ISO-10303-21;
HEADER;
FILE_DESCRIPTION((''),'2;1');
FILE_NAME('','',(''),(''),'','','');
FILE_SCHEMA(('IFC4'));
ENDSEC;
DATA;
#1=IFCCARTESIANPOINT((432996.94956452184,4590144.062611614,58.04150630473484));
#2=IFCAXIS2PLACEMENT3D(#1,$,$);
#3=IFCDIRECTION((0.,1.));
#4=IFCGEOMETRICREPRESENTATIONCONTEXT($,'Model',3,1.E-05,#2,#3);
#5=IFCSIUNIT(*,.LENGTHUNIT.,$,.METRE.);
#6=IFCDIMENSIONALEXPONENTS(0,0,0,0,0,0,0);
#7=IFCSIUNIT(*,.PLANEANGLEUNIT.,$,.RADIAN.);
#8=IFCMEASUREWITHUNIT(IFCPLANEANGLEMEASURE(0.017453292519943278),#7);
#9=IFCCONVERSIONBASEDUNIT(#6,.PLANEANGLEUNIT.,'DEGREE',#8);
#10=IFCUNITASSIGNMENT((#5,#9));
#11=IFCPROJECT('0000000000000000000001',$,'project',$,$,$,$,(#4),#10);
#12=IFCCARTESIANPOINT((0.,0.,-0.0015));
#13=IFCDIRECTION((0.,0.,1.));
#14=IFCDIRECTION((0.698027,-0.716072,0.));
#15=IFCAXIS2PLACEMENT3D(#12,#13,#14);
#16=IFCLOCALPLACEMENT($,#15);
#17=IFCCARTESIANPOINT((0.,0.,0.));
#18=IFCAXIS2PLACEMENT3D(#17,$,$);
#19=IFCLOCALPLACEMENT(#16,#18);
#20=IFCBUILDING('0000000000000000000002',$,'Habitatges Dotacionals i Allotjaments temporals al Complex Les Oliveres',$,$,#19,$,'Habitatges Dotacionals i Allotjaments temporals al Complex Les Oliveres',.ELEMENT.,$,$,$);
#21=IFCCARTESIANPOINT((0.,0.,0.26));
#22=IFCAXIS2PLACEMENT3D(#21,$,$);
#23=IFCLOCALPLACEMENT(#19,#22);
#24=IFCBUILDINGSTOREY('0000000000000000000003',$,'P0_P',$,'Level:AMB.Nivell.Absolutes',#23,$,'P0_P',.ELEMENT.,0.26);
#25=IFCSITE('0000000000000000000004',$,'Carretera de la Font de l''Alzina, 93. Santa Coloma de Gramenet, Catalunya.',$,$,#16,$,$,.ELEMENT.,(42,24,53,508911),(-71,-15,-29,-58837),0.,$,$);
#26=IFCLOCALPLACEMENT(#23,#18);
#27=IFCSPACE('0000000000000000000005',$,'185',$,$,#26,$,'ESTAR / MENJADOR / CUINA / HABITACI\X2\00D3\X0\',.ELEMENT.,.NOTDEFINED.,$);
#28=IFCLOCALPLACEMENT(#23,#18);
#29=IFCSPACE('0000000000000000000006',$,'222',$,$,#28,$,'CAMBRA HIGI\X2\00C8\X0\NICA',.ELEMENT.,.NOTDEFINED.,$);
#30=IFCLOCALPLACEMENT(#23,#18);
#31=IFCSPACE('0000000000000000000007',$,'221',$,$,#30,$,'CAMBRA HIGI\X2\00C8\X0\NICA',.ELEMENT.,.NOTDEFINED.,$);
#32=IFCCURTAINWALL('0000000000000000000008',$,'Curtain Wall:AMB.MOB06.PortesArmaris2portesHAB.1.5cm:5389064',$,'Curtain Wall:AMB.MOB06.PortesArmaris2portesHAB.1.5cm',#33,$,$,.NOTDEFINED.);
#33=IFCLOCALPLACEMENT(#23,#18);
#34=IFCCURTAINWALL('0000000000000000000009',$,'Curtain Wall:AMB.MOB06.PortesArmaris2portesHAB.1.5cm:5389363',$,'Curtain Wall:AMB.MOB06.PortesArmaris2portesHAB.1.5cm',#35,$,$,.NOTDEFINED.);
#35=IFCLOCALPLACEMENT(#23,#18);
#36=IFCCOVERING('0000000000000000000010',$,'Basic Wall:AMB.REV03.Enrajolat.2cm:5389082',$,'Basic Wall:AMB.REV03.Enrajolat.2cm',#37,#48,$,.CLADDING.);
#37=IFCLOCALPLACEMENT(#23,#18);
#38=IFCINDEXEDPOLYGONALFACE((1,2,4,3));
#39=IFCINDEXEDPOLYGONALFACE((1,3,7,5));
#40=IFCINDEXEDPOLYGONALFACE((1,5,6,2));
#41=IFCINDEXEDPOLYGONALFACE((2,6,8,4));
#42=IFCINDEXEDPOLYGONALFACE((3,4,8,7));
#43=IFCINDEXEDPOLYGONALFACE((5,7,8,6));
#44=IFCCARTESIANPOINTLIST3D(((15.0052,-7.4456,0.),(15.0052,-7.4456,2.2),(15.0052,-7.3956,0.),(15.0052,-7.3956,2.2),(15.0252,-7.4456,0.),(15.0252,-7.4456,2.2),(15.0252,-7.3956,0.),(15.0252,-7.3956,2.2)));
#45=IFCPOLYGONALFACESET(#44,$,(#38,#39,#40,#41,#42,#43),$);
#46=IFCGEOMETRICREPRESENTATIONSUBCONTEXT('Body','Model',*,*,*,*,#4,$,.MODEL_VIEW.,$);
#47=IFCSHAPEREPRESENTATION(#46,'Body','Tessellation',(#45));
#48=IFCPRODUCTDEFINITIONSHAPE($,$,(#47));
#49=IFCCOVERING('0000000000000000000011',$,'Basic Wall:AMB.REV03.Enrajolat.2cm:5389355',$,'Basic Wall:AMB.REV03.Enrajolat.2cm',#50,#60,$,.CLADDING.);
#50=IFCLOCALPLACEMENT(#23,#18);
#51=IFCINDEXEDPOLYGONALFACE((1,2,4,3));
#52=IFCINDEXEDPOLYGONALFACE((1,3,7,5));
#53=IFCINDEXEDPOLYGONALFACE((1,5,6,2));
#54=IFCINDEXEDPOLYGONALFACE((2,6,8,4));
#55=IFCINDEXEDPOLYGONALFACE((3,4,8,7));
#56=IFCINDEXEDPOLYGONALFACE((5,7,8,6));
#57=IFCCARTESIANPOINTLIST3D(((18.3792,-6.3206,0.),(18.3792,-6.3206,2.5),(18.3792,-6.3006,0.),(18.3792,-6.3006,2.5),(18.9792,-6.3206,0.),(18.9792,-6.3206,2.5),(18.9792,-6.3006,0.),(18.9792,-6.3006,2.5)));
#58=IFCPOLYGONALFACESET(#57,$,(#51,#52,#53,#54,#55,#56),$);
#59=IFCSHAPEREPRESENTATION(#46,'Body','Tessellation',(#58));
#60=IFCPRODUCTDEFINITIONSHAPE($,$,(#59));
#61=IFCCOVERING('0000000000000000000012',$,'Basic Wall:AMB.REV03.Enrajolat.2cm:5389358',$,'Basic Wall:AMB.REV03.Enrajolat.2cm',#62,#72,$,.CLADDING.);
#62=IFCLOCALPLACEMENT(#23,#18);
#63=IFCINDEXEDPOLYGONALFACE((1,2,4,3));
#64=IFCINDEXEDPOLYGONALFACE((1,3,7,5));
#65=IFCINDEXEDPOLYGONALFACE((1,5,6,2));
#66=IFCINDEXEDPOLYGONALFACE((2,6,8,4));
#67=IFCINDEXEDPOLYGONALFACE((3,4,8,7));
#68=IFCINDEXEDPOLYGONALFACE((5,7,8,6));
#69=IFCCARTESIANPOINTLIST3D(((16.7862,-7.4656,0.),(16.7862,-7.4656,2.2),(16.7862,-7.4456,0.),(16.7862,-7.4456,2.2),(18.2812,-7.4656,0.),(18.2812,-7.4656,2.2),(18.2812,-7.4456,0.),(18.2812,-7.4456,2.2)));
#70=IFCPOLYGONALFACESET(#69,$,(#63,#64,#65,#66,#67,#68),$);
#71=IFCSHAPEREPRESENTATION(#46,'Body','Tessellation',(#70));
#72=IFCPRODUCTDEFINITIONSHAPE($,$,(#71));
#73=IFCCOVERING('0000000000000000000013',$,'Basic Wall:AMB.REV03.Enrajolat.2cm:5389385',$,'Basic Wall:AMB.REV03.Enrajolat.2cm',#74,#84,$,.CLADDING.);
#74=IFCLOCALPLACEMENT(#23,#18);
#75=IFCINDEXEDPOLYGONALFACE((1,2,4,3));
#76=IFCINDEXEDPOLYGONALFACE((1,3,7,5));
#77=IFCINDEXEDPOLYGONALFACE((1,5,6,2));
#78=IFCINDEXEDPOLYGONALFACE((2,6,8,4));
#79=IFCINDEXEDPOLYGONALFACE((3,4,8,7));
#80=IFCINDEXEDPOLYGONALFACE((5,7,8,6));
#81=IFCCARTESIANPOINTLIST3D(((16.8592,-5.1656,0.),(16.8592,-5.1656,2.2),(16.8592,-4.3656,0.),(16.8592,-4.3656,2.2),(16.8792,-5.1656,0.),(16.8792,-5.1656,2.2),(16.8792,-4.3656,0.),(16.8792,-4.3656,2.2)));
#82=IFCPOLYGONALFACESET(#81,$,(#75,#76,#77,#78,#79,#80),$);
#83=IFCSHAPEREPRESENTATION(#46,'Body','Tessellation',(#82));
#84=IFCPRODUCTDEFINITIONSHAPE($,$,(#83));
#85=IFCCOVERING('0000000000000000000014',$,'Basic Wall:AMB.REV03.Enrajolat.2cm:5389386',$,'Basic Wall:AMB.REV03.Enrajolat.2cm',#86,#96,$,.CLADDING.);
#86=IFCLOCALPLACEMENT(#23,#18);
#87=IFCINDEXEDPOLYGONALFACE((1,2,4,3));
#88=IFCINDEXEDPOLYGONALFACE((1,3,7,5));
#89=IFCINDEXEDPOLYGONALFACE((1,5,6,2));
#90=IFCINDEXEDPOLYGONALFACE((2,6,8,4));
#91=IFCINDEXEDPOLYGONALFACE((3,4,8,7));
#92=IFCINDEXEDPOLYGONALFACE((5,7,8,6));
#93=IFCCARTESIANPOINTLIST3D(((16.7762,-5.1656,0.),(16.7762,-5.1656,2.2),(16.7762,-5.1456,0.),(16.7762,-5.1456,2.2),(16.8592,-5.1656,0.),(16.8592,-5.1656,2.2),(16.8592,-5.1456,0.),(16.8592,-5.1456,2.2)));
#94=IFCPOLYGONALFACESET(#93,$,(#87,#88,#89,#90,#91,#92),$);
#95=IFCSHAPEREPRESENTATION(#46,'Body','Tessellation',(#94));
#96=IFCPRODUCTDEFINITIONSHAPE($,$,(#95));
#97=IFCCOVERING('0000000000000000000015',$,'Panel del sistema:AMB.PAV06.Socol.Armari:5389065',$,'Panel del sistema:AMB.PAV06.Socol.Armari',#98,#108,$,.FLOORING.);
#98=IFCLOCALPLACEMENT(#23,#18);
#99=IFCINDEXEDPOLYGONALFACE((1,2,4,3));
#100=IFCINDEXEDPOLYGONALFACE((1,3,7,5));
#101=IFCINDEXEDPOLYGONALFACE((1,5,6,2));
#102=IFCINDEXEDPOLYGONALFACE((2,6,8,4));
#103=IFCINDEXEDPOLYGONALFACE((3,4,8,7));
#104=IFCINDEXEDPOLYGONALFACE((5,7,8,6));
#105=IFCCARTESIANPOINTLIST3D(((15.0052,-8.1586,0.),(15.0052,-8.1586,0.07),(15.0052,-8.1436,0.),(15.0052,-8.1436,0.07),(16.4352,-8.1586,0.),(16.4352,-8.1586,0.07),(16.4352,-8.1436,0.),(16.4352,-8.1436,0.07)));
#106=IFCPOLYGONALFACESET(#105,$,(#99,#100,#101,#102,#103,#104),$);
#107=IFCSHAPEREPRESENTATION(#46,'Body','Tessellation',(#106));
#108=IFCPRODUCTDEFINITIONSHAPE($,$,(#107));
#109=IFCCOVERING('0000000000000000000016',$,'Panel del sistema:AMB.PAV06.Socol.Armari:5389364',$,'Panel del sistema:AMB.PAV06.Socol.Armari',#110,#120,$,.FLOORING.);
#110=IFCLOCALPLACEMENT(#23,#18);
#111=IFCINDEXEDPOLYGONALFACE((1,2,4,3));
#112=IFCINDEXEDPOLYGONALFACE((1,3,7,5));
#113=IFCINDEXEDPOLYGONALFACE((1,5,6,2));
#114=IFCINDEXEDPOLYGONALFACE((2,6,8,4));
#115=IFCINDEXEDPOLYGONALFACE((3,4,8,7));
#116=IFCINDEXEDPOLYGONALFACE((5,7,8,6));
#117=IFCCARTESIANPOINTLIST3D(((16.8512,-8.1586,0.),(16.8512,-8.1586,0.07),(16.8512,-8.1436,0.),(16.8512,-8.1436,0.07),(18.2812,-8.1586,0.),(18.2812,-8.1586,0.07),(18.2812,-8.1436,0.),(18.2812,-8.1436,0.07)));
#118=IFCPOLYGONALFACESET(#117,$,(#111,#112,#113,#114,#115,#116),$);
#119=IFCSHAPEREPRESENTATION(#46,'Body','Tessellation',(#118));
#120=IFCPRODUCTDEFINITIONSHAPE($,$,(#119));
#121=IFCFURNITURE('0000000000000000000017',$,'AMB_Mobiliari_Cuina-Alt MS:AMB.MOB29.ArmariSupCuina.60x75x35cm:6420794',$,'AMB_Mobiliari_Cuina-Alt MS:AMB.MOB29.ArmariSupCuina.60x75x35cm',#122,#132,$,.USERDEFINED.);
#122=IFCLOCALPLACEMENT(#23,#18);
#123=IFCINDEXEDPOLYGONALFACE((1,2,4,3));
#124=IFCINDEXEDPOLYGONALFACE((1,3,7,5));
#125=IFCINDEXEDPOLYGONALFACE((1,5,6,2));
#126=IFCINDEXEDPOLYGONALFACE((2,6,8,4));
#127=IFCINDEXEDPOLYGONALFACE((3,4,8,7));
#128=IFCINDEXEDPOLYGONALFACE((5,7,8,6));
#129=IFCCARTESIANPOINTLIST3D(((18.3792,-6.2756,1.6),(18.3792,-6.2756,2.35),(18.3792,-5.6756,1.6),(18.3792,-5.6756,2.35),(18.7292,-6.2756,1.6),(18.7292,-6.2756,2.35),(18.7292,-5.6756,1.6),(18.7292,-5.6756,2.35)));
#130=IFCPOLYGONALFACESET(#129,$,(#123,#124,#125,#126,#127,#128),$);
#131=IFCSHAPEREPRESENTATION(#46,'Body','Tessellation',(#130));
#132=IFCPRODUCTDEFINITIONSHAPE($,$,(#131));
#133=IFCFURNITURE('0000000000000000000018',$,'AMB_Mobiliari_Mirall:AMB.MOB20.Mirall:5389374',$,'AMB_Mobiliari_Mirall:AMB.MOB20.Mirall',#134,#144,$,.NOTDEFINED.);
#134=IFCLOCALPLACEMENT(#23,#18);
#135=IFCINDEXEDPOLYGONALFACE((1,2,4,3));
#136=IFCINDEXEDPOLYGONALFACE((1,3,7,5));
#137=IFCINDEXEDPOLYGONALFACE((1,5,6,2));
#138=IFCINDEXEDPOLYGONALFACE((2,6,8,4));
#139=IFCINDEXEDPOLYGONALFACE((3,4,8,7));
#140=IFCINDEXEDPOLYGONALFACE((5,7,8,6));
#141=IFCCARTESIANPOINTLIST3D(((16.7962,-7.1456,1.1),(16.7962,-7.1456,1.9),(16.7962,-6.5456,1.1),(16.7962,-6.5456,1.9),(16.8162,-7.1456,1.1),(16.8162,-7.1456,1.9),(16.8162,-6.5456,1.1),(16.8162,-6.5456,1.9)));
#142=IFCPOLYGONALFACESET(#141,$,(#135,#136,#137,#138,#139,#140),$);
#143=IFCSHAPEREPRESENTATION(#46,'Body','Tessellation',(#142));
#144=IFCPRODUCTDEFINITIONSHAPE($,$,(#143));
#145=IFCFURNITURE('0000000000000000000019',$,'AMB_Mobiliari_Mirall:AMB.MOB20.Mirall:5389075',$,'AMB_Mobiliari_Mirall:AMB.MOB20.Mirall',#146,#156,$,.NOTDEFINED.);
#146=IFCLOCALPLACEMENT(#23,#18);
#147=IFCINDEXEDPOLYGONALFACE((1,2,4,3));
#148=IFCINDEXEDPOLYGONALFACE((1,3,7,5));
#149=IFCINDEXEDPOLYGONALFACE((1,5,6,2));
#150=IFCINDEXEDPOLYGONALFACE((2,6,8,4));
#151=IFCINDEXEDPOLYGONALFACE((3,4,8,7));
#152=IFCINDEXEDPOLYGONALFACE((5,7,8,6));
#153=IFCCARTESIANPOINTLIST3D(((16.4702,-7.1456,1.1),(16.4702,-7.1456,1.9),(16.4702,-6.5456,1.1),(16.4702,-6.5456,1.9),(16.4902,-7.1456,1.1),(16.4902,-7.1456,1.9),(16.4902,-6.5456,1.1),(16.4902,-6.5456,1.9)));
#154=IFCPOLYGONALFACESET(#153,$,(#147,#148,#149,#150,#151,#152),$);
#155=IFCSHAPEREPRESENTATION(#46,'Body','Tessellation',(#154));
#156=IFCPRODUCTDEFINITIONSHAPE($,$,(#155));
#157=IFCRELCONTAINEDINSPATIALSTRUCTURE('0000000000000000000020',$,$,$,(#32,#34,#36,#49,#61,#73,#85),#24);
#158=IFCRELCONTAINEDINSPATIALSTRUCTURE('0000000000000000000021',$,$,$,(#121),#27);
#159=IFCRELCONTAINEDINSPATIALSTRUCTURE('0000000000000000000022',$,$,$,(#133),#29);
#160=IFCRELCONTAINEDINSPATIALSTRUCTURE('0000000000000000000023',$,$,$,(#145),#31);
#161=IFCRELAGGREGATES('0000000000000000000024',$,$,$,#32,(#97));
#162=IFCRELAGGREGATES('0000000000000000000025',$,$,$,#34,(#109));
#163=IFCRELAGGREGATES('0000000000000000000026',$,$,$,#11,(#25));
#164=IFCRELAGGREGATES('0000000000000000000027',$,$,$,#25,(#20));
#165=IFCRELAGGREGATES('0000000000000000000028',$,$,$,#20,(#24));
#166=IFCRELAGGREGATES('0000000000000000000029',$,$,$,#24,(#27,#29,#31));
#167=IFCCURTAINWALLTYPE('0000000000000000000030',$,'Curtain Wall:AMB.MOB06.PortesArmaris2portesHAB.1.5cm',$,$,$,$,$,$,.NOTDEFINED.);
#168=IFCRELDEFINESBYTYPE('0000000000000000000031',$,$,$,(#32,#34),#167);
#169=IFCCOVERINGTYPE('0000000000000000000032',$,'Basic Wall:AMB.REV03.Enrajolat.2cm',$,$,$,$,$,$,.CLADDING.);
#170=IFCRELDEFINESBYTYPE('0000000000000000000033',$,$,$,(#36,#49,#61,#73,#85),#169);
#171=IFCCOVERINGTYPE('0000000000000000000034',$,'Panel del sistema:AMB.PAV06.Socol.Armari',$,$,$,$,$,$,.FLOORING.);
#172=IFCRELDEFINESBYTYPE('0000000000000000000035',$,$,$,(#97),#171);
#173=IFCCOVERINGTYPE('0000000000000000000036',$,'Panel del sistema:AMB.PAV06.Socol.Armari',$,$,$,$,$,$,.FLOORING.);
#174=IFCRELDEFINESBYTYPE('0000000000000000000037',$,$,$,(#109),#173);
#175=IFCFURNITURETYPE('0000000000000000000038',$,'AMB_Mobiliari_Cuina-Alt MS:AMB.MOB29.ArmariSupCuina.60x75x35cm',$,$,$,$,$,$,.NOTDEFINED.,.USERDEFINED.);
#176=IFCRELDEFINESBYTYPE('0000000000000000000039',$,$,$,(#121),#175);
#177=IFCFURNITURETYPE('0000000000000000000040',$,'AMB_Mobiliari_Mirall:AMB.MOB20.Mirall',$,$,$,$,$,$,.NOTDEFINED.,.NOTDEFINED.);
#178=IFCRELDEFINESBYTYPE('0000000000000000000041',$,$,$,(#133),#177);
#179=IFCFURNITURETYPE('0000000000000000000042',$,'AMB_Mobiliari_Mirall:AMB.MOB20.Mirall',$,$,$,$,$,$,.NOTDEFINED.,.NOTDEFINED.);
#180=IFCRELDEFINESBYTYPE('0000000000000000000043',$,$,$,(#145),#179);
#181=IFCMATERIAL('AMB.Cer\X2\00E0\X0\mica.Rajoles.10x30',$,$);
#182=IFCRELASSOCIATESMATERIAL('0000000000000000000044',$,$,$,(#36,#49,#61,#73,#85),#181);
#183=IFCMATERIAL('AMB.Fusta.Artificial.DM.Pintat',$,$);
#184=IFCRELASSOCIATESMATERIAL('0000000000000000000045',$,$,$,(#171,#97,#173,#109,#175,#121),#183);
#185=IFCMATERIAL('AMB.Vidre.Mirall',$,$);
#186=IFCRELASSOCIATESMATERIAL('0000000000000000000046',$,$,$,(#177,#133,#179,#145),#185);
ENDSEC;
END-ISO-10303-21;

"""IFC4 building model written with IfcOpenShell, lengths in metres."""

from ifc_helpers import new_model, entity, si_unit, converted_unit, direction, frame, origin, place, context, subcontext, project, spatial, indexed_curve, outline, extrude, source, transform, mapped, material, type_object, type_shapes, element, aggregate, save


model = new_model("IFC4")

# Units and contexts
model_context = context("Model", 3, precision=1e-05, world=frame((432996.94956452184, 4590144.062611614, 58.04150630473484)), true_north=direction((0.0, 1.0)))
body_context = subcontext(model_context, "Body", "Model", "MODEL_VIEW")
ifc_project = project(units=[si_unit("LENGTHUNIT", "METRE"), converted_unit("PLANEANGLEUNIT", "DEGREE", entity("IfcPlaneAngleMeasure", 0.017453292519943278), si_unit("PLANEANGLEUNIT", "RADIAN"), dimensions=[0, 0, 0, 0, 0, 0, 0])], contexts=[model_context])

# Site, building, storey
site_placement = place(None, frame((0.0, 0.0, -0.0015), z_axis=(0.0, 0.0, 1.0), x_axis=(0.698027, -0.716072, 0.0)))
site = spatial("IfcSite", under=ifc_project, at=site_placement, Name="Carretera de la Font de l'Alzina, 93. Santa Coloma de Gramenet, Catalunya.", CompositionType="ELEMENT", RefLatitude=(42, 24, 53, 508911), RefLongitude=(-71, -15, -29, -58837), RefElevation=0.0)
building_placement = place(site_placement, origin())
building = spatial("IfcBuilding", under=site, at=building_placement, Name="Habitatges Dotacionals i Allotjaments temporals al Complex Les Oliveres", LongName="Habitatges Dotacionals i Allotjaments temporals al Complex Les Oliveres", CompositionType="ELEMENT")
storey_placement = place(building_placement, frame((0.0, 0.0, 0.26)))
storey = spatial("IfcBuildingStorey", under=building, at=storey_placement, Name="P0_P", ObjectType="Level:AMB.Nivell.Absolutes", LongName="P0_P", CompositionType="ELEMENT", Elevation=0.26)

# Curtain walls
curtain_wall_type = type_object("IfcCurtainWallType", Name="Curtain Wall:AMB.MOB06.PortesArmaris2portesHAB.1.5cm", PredefinedType="NOTDEFINED")
curtain_wall_1_placement = place(storey_placement, frame((0.0, 0.0, -0.26)))
curtain_wall_1 = element("IfcCurtainWall", 1, at=curtain_wall_1_placement, inside=storey, type_object=curtain_wall_type, Name="Curtain Wall:AMB.MOB06.PortesArmaris2portesHAB.1.5cm:5389064", ObjectType="Curtain Wall:AMB.MOB06.PortesArmaris2portesHAB.1.5cm", PredefinedType="NOTDEFINED")
ifc_material_1 = material(Name="AMB.Fusta.Artificial.DM.Pintat")
curtain_wall_2_placement = place(storey_placement, frame((0.0, 0.0, -0.26)))
curtain_wall_2 = element("IfcCurtainWall", 2, at=curtain_wall_2_placement, inside=storey, type_object=curtain_wall_type, Name="Curtain Wall:AMB.MOB06.PortesArmaris2portesHAB.1.5cm:5389363", ObjectType="Curtain Wall:AMB.MOB06.PortesArmaris2portesHAB.1.5cm", PredefinedType="NOTDEFINED")

# Coverings
ifc_material_2 = material(Name="AMB.Ceràmica.Rajoles.10x30")
covering_type_1 = type_object("IfcCoveringType", Name="Basic Wall:AMB.REV03.Enrajolat.2cm", PredefinedType="CLADDING")
covering_1_placement = place(storey_placement, frame((15.0152, -7.4456, 0.0), z_axis=(0.0, 0.0, 1.0), x_axis=(0.0, 1.0, 0.0)))
element("IfcCovering", 3, at=covering_1_placement, inside=storey, type_object=covering_type_1, material=ifc_material_2, Name="Basic Wall:AMB.REV03.Enrajolat.2cm:5389082", ObjectType="Basic Wall:AMB.REV03.Enrajolat.2cm", PredefinedType="CLADDING", context=body_context, shape_type="SweptSolid", body=[
    extrude(outline(indexed_curve([(0.05, 0.01), (0.0, 0.01), (0.0, -0.01), (0.05, -0.01), (0.05, 0.01)], self_intersect=False)), origin(), (0.0, 0.0, 1.0), 2.2),
])
covering_2_placement = place(storey_placement, frame((18.3792, -6.3106, 0.0)))
element("IfcCovering", 4, at=covering_2_placement, inside=storey, type_object=covering_type_1, material=ifc_material_2, Name="Basic Wall:AMB.REV03.Enrajolat.2cm:5389355", ObjectType="Basic Wall:AMB.REV03.Enrajolat.2cm", PredefinedType="CLADDING", context=body_context, shape_type="SweptSolid", body=[
    extrude(outline(indexed_curve([(0.6, 0.01), (0.0, 0.01), (0.0, -0.01), (0.6, -0.01), (0.6, 0.01)], self_intersect=False)), origin(), (0.0, 0.0, 1.0), 2.5),
])
covering_3_placement = place(storey_placement, frame((18.2812, -7.4556, 0.0), z_axis=(0.0, 0.0, 1.0), x_axis=(-1.0, 0.0, 0.0)))
element("IfcCovering", 5, at=covering_3_placement, inside=storey, type_object=covering_type_1, material=ifc_material_2, Name="Basic Wall:AMB.REV03.Enrajolat.2cm:5389358", ObjectType="Basic Wall:AMB.REV03.Enrajolat.2cm", PredefinedType="CLADDING", context=body_context, shape_type="SweptSolid", body=[
    extrude(outline(indexed_curve([(1.495, 0.01), (0.0, 0.01), (0.0, -0.01), (1.495, -0.01), (1.495, 0.01)], self_intersect=False)), origin(), (0.0, 0.0, 1.0), 2.2),
])
covering_4_placement = place(storey_placement, frame((16.8692, -5.1656, 0.0), z_axis=(0.0, 0.0, 1.0), x_axis=(0.0, 1.0, 0.0)))
element("IfcCovering", 6, at=covering_4_placement, inside=storey, type_object=covering_type_1, material=ifc_material_2, Name="Basic Wall:AMB.REV03.Enrajolat.2cm:5389385", ObjectType="Basic Wall:AMB.REV03.Enrajolat.2cm", PredefinedType="CLADDING", context=body_context, shape_type="SweptSolid", body=[
    extrude(outline(indexed_curve([(0.8, 0.01), (0.0, 0.01), (0.0, -0.01), (0.8, -0.01), (0.8, 0.01)], self_intersect=False)), origin(), (0.0, 0.0, 1.0), 2.2),
])
covering_5_placement = place(storey_placement, frame((16.8592, -5.1556, 0.0), z_axis=(0.0, 0.0, 1.0), x_axis=(-1.0, 0.0, 0.0)))
element("IfcCovering", 7, at=covering_5_placement, inside=storey, type_object=covering_type_1, material=ifc_material_2, Name="Basic Wall:AMB.REV03.Enrajolat.2cm:5389386", ObjectType="Basic Wall:AMB.REV03.Enrajolat.2cm", PredefinedType="CLADDING", context=body_context, shape_type="SweptSolid", body=[
    extrude(outline(indexed_curve([(0.083, 0.01), (0.0, 0.01), (0.0, -0.01), (0.083, -0.01), (0.083, 0.01)], self_intersect=False)), origin(), (0.0, 0.0, 1.0), 2.2),
])

# Coverings
covering_type_2 = type_object("IfcCoveringType", Name="Panel del sistema:AMB.PAV06.Socol.Armari", PredefinedType="FLOORING", material=ifc_material_1)
shared_shape_1 = source(origin(), body_context, "Body", "SweptSolid", [
    extrude(outline(indexed_curve([(-0.0075, -0.715), (0.0075, -0.715), (0.0075, 0.715), (-0.0075, 0.715), (-0.0075, -0.715)], self_intersect=False)), frame((0.0, -0.0075, 0.0), z_axis=(0.0, 0.0, 1.0), x_axis=(0.0, 1.0, 0.0)), (0.0, 0.0, 1.0), 0.07),
])
type_shapes(covering_type_2, [shared_shape_1])
covering_6_placement = place(storey_placement, frame((15.7202, -8.1586, 0.0), z_axis=(0.0, 0.0, 1.0), x_axis=(-1.0, 0.0, 0.0)))
covering_6 = element("IfcCovering", 8, at=covering_6_placement, type_object=covering_type_2, material=ifc_material_1, Name="Panel del sistema:AMB.PAV06.Socol.Armari:5389065", ObjectType="Panel del sistema:AMB.PAV06.Socol.Armari", PredefinedType="FLOORING", context=body_context, shape_type="MappedRepresentation", body=[
    mapped(shared_shape_1, transform((0.0, 0.0, 0.0), scale=1.0)),
])
aggregate(curtain_wall_1, [covering_6])
covering_type_3 = type_object("IfcCoveringType", Name="Panel del sistema:AMB.PAV06.Socol.Armari", PredefinedType="FLOORING", material=ifc_material_1)
shared_shape_2 = source(origin(), body_context, "Body", "SweptSolid", [
    extrude(outline(indexed_curve([(-0.0075, -0.715), (0.0075, -0.715), (0.0075, 0.715), (-0.0075, 0.715), (-0.0075, -0.715)], self_intersect=False)), frame((0.0, 0.0075, 0.0), z_axis=(0.0, 0.0, 1.0), x_axis=(0.0, 1.0, 0.0)), (0.0, 0.0, 1.0), 0.07),
])
type_shapes(covering_type_3, [shared_shape_2])
covering_7_placement = place(storey_placement, frame((17.5662, -8.1586, 0.0)))
covering_7 = element("IfcCovering", 9, at=covering_7_placement, type_object=covering_type_3, material=ifc_material_1, Name="Panel del sistema:AMB.PAV06.Socol.Armari:5389364", ObjectType="Panel del sistema:AMB.PAV06.Socol.Armari", PredefinedType="FLOORING", context=body_context, shape_type="MappedRepresentation", body=[
    mapped(shared_shape_2, transform((0.0, 0.0, 0.0), scale=1.0)),
])
aggregate(curtain_wall_2, [covering_7])

# Shared definitions
space_1_placement = place(storey_placement, origin())
space_1 = spatial("IfcSpace", under=storey, at=space_1_placement, Name="185", LongName="ESTAR / MENJADOR / CUINA / HABITACIÓ", CompositionType="ELEMENT", PredefinedType="NOTDEFINED")

# Furniture
furniture_type_1 = type_object("IfcFurnitureType", Name="AMB_Mobiliari_Cuina-Alt MS:AMB.MOB29.ArmariSupCuina.60x75x35cm", AssemblyPlace="NOTDEFINED", PredefinedType="USERDEFINED", material=ifc_material_1)
shared_shape_3 = source(origin(), body_context, "Body", "SweptSolid", [
    extrude(outline(indexed_curve([(-0.3, -0.175), (0.3, -0.175), (0.3, 0.175), (-0.3, 0.175), (-0.3, -0.175)], self_intersect=False)), frame((-0.5175, -0.175, 0.0), z_axis=(0.0, 0.0, 1.0), x_axis=(-1.0, 0.0, 0.0)), (0.0, 0.0, 1.0), 0.75),
])
type_shapes(furniture_type_1, [shared_shape_3])
furniture_1_placement = place(space_1_placement, frame((18.3792, -5.4581, 1.6), z_axis=(0.0, 0.0, 1.0), x_axis=(0.0, 1.0, 0.0)))
element("IfcFurniture", 10, at=furniture_1_placement, inside=space_1, type_object=furniture_type_1, material=ifc_material_1, Name="AMB_Mobiliari_Cuina-Alt MS:AMB.MOB29.ArmariSupCuina.60x75x35cm:6420794", ObjectType="AMB_Mobiliari_Cuina-Alt MS:AMB.MOB29.ArmariSupCuina.60x75x35cm", PredefinedType="USERDEFINED", context=body_context, shape_type="MappedRepresentation", body=[
    mapped(shared_shape_3, transform((0.0, 0.0, 0.0), scale=1.0)),
])

# Shared definitions
space_2_placement = place(storey_placement, origin())
space_2 = spatial("IfcSpace", under=storey, at=space_2_placement, Name="222", LongName="CAMBRA HIGIÈNICA", CompositionType="ELEMENT", PredefinedType="NOTDEFINED")

# Furniture
ifc_material_3 = material(Name="AMB.Vidre.Mirall")
furniture_type_2 = type_object("IfcFurnitureType", Name="AMB_Mobiliari_Mirall:AMB.MOB20.Mirall", AssemblyPlace="NOTDEFINED", PredefinedType="NOTDEFINED", material=ifc_material_3)
shared_shape_4 = source(origin(), body_context, "Body", "SweptSolid", [
    extrude(outline(indexed_curve([(-0.01, -0.3), (0.01, -0.3), (0.01, 0.3), (-0.01, 0.3), (-0.01, -0.3)], self_intersect=False)), frame((0.3, 0.01, 1.0), z_axis=(0.0, 0.0, 1.0), x_axis=(0.0, 1.0, 0.0)), (0.0, 0.0, 1.0), 0.8),
])
type_shapes(furniture_type_2, [shared_shape_4])
furniture_2_placement = place(space_2_placement, frame((16.8162, -7.1456, 0.1), z_axis=(0.0, 0.0, 1.0), x_axis=(0.0, 1.0, 0.0)))
element("IfcFurniture", 11, at=furniture_2_placement, inside=space_2, type_object=furniture_type_2, material=ifc_material_3, Name="AMB_Mobiliari_Mirall:AMB.MOB20.Mirall:5389374", ObjectType="AMB_Mobiliari_Mirall:AMB.MOB20.Mirall", PredefinedType="NOTDEFINED", context=body_context, shape_type="MappedRepresentation", body=[
    mapped(shared_shape_4, transform((0.0, 0.0, 0.0), scale=1.0)),
])

# Shared definitions
space_3_placement = place(storey_placement, origin())
space_3 = spatial("IfcSpace", under=storey, at=space_3_placement, Name="221", LongName="CAMBRA HIGIÈNICA", CompositionType="ELEMENT", PredefinedType="NOTDEFINED")

# Furniture
furniture_type_3 = type_object("IfcFurnitureType", Name="AMB_Mobiliari_Mirall:AMB.MOB20.Mirall", AssemblyPlace="NOTDEFINED", PredefinedType="NOTDEFINED", material=ifc_material_3)
shared_shape_5 = source(origin(), body_context, "Body", "SweptSolid", [
    extrude(outline(indexed_curve([(-0.3, -0.01), (0.3, -0.01), (0.3, 0.01), (-0.3, 0.01), (-0.3, -0.01)], self_intersect=False)), frame((0.3, -0.01, 1.0), z_axis=(0.0, 0.0, 1.0), x_axis=(-1.0, 0.0, 0.0)), (0.0, 0.0, 1.0), 0.8),
])
type_shapes(furniture_type_3, [shared_shape_5])
furniture_3_placement = place(space_3_placement, frame((16.4702, -7.1456, 0.1), z_axis=(0.0, 0.0, 1.0), x_axis=(0.0, 1.0, 0.0)))
element("IfcFurniture", 12, at=furniture_3_placement, inside=space_3, type_object=furniture_type_3, material=ifc_material_3, Name="AMB_Mobiliari_Mirall:AMB.MOB20.Mirall:5389075", ObjectType="AMB_Mobiliari_Mirall:AMB.MOB20.Mirall", PredefinedType="NOTDEFINED", context=body_context, shape_type="MappedRepresentation", body=[
    mapped(shared_shape_5, transform((0.0, 0.0, 0.0), scale=1.0)),
])

save(model, "model.ifc")
